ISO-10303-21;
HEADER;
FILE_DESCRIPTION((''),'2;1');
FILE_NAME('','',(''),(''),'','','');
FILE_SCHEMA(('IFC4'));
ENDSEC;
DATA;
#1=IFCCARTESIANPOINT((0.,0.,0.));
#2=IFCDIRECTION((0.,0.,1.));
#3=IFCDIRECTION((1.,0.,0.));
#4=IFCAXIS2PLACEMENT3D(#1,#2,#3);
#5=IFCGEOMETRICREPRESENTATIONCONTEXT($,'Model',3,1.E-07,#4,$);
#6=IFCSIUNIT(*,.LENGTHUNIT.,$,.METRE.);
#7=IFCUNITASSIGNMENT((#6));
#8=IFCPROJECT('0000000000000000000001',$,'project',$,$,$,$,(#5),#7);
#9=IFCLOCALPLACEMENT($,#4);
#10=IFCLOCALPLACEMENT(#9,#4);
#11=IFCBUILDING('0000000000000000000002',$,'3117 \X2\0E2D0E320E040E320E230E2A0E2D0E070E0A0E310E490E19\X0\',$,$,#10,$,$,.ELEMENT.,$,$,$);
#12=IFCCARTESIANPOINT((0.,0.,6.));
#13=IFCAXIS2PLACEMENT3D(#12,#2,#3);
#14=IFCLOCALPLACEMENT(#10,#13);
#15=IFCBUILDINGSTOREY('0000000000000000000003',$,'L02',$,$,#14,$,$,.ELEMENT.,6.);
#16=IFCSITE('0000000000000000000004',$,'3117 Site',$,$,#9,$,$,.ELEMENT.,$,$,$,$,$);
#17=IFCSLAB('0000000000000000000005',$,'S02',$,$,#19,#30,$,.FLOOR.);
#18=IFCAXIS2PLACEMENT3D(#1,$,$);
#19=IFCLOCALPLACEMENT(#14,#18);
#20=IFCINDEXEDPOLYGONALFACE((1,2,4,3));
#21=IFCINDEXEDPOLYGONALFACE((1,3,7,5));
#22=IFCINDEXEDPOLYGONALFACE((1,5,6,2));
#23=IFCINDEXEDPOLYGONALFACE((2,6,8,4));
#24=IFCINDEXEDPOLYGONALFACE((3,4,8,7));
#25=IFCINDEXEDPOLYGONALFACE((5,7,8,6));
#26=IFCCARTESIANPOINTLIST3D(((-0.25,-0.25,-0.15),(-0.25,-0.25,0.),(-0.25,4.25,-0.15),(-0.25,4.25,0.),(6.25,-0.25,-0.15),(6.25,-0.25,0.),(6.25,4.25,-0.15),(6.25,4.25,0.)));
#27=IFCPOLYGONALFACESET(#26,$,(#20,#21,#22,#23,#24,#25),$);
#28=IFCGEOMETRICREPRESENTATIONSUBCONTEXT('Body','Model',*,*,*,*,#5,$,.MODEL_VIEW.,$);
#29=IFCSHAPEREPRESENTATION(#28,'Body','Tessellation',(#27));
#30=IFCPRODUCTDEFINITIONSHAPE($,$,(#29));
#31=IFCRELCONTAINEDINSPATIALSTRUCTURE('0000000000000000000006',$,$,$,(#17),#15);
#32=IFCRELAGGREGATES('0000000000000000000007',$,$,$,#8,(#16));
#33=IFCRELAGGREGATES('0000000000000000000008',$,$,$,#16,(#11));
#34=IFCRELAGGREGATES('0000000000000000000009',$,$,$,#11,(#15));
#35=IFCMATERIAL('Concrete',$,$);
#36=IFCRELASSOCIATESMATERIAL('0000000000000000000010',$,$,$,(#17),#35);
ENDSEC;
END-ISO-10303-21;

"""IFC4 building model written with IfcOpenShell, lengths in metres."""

from ifc_helpers import new_model, si_unit, frame, origin_with_axes, place, context, subcontext, project, spatial, polyline, outline, extrude, material, element, save


model = new_model("IFC4")

# Units and contexts
model_context = context("Model", 3, precision=1e-07, world=origin_with_axes())
body_context = subcontext(model_context, "Body", "Model", "MODEL_VIEW")
ifc_project = project(units=[si_unit("LENGTHUNIT", "METRE")], contexts=[model_context])

# Site, building, storey
site_placement = place(None, origin_with_axes())
site = spatial("IfcSite", under=ifc_project, at=site_placement, Name="3117 Site", CompositionType="ELEMENT")
building_placement = place(site_placement, origin_with_axes())
building = spatial("IfcBuilding", under=site, at=building_placement, Name="3117 อาคารสองชั้น", CompositionType="ELEMENT")
storey_placement = place(building_placement, frame((0.0, 0.0, 6.0), z_axis=(0.0, 0.0, 1.0), x_axis=(1.0, 0.0, 0.0)))
storey = spatial("IfcBuildingStorey", under=building, at=storey_placement, Name="L02", CompositionType="ELEMENT", Elevation=6.0)

# Slab
ifc_material_1 = material(Name="Concrete")
slab_placement = place(storey_placement, frame((0.0, 0.0, -0.15), z_axis=(0.0, 0.0, 1.0), x_axis=(1.0, 0.0, 0.0)))
element("IfcSlab", 1, at=slab_placement, inside=storey, material=ifc_material_1, Name="S02", PredefinedType="FLOOR", context=body_context, shape_type="SweptSolid", body=[
    extrude(outline(polyline([(-0.25, -0.25), (6.25, -0.25), (6.25, 4.25), (-0.25, 4.25), (-0.25, -0.25)])), origin_with_axes(), (0.0, 0.0, 1.0), 0.15),
])

save(model, "model.ifc")
